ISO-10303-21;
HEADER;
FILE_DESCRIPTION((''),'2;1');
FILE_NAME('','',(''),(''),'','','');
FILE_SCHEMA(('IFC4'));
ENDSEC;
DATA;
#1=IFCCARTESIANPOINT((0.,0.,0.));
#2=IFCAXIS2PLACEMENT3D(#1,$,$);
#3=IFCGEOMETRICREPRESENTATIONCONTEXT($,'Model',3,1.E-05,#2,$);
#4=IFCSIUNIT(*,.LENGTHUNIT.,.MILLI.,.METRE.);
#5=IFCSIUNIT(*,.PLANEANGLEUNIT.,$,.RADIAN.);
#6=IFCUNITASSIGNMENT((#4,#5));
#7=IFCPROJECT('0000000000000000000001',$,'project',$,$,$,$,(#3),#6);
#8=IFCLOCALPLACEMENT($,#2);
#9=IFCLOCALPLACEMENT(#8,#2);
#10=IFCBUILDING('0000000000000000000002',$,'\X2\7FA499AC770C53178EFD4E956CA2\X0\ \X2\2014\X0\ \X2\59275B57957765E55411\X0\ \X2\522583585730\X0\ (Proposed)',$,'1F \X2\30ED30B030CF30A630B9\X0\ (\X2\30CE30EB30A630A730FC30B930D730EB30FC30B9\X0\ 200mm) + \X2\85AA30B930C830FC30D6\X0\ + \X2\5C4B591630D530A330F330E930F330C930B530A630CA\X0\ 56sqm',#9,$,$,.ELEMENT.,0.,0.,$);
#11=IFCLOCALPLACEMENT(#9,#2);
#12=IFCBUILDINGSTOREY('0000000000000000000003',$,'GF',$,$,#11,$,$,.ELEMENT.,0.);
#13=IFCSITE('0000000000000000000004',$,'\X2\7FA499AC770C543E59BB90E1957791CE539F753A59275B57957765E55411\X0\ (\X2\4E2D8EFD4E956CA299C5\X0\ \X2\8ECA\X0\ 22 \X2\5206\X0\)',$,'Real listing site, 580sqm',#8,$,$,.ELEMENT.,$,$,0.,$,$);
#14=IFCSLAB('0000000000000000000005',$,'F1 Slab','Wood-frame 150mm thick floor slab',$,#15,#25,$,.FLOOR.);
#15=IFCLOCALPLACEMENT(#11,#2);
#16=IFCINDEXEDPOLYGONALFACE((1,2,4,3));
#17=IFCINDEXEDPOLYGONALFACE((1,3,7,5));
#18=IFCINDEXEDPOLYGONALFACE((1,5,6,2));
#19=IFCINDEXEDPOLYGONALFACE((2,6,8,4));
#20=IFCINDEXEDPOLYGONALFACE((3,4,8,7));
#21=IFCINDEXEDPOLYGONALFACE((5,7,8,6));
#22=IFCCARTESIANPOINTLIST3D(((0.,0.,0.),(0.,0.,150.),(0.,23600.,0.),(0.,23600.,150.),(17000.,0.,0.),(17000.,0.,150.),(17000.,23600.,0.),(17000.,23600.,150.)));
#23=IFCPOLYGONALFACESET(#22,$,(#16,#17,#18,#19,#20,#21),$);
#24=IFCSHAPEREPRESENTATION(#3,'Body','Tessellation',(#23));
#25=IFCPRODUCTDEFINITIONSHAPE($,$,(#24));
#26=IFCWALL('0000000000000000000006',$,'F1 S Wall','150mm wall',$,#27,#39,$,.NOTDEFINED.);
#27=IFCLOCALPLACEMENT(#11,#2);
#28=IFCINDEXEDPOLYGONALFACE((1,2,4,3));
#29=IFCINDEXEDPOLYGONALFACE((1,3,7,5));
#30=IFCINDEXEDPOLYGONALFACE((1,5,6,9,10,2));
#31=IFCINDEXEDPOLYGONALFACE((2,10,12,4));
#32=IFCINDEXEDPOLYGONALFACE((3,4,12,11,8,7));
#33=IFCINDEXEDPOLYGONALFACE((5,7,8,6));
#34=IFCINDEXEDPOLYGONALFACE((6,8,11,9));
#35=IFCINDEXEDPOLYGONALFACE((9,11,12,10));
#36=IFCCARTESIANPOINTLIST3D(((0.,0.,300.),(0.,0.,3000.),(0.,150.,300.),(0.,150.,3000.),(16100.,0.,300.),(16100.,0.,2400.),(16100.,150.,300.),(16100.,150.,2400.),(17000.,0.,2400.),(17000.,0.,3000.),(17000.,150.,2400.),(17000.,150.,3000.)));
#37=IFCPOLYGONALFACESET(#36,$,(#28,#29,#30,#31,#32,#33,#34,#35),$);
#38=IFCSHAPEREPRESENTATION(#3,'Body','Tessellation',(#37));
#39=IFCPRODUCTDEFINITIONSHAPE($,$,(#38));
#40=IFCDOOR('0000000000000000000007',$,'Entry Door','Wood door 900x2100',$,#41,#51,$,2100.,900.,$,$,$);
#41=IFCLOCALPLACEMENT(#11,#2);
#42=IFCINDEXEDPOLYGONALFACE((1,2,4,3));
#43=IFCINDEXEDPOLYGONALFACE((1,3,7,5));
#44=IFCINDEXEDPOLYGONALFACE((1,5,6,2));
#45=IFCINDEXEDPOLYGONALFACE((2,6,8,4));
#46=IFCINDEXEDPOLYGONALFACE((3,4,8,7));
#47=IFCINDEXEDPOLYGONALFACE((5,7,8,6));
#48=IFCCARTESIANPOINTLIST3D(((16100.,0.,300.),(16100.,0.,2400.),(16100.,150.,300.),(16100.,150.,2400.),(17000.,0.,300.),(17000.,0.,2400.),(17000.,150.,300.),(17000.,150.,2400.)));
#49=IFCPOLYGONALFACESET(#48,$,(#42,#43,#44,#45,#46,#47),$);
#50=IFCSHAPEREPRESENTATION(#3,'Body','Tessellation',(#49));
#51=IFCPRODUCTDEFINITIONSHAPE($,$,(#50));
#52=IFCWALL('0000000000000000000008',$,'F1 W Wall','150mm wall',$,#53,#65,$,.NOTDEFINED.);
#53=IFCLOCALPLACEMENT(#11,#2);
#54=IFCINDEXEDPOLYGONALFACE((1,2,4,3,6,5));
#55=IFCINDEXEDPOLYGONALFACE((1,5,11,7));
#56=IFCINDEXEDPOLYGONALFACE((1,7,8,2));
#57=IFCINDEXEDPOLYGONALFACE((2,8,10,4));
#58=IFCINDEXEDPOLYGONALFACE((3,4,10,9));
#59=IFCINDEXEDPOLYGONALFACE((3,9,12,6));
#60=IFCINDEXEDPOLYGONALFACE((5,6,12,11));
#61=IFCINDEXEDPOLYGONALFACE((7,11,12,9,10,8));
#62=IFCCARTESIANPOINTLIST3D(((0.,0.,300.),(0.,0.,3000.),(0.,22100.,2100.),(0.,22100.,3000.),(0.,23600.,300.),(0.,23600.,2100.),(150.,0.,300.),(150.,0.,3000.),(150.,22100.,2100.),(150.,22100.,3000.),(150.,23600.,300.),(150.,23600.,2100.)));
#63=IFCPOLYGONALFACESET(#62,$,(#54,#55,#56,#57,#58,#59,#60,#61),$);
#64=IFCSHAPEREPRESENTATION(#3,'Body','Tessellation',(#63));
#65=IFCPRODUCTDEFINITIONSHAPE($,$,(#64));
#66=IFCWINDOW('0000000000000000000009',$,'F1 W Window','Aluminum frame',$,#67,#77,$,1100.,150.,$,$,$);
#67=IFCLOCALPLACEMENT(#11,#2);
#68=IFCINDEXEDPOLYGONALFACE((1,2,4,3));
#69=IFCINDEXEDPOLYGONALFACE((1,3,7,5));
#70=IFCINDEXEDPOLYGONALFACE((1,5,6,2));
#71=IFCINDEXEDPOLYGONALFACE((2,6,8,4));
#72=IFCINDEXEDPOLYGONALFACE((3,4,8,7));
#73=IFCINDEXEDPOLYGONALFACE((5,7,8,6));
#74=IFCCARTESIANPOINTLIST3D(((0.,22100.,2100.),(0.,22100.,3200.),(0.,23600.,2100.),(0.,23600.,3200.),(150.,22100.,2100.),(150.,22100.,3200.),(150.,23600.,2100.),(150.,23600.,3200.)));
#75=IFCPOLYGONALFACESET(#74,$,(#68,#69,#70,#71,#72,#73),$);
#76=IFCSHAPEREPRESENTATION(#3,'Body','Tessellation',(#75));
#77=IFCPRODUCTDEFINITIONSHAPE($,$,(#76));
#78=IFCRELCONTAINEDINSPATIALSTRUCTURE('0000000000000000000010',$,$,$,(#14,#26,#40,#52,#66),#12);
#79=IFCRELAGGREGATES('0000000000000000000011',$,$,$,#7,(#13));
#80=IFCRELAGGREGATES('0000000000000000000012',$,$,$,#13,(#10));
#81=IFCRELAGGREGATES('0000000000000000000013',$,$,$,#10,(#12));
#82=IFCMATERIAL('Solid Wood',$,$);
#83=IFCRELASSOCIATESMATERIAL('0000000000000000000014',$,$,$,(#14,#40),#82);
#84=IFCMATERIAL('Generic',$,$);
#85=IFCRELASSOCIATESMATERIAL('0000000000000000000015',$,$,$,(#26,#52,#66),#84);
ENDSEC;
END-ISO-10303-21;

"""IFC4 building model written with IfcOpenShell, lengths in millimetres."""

from ifc_helpers import new_model, si_unit, frame, frame_2d, origin, place, context, project, spatial, rectangle, extrude, material, element, fill, save


model = new_model("IFC4")

# Units and contexts
model_context = context("Model", 3, precision=1e-05, world=origin())
ifc_project = project(units=[si_unit("LENGTHUNIT", "METRE", prefix="MILLI"), si_unit("PLANEANGLEUNIT", "RADIAN")], contexts=[model_context])

# Site, building, storey
site_placement = place(None, origin())
site = spatial("IfcSite", under=ifc_project, at=site_placement, Name="群馬県吾妻郡長野原町大字長日向 (中軽井沢駅 車 22 分)", ObjectType="Real listing site, 580sqm", CompositionType="ELEMENT", RefElevation=0.0)
building_placement = place(site_placement, origin())
building = spatial("IfcBuilding", under=site, at=building_placement, Name="群馬県北軽井沢 — 大字長日向 別荘地 (Proposed)", ObjectType="1F ログハウス (ノルウェースプルース 200mm) + 薪ストーブ + 屋外フィンランドサウナ 56sqm", CompositionType="ELEMENT", ElevationOfRefHeight=0.0, ElevationOfTerrain=0.0)
storey_placement = place(building_placement, origin())
storey = spatial("IfcBuildingStorey", under=building, at=storey_placement, Name="GF", CompositionType="ELEMENT", Elevation=0.0)

# Slab
ifc_material_1 = material(Name="Solid Wood")
slab_placement = place(storey_placement, origin())
element("IfcSlab", 1, at=slab_placement, inside=storey, material=ifc_material_1, Name="F1 Slab", Description="Wood-frame 150mm thick floor slab", PredefinedType="FLOOR", context=model_context, shape_type="SweptSolid", body=[
    extrude(rectangle(XDim=17000.0, YDim=23600.0, at=frame_2d((8500.0, 11800.0))), origin(), (0.0, 0.0, 1.0), 150.0),
])

# Shared definitions
ifc_material_2 = material(Name="Generic")

# Wall, opening, door
wall_1_placement = place(storey_placement, frame((0.0, 0.0, 150.0)))
wall_1 = element("IfcWall", 2, at=wall_1_placement, inside=storey, material=ifc_material_2, Name="F1 S Wall", Description="150mm wall", PredefinedType="NOTDEFINED", context=model_context, shape_type="SweptSolid", body=[
    extrude(rectangle(XDim=17000.0, YDim=150.0, at=frame_2d((8500.0, 75.0))), frame((0.0, 0.0, 150.0)), (0.0, 0.0, 1.0), 2700.0),
])
opening_1_placement = place(storey_placement, frame((8050.0, 0.0, 150.0)))
opening_1 = element("IfcOpeningElement", 3, at=opening_1_placement, cuts=wall_1, PredefinedType="NOTDEFINED", context=model_context, shape_type="SweptSolid", body=[
    extrude(rectangle(XDim=900.0, YDim=150.0, at=frame_2d((450.0, 75.0))), frame((8050.0, 0.0, 150.0)), (0.0, 0.0, 1.0), 2100.0),
])
door_placement = place(storey_placement, frame((8050.0, 0.0, 150.0)))
door = element("IfcDoor", 4, at=door_placement, inside=storey, material=ifc_material_1, Name="Entry Door", Description="Wood door 900x2100", OverallHeight=2100.0, OverallWidth=900.0, context=model_context, shape_type="SweptSolid", body=[
    extrude(rectangle(XDim=900.0, YDim=150.0, at=frame_2d((450.0, 75.0))), frame((8050.0, 0.0, 150.0)), (0.0, 0.0, 1.0), 2100.0),
])
fill(opening_1, door)

# Wall, opening, window
wall_2_placement = place(storey_placement, frame((0.0, 0.0, 150.0)))
wall_2 = element("IfcWall", 5, at=wall_2_placement, inside=storey, material=ifc_material_2, Name="F1 W Wall", Description="150mm wall", PredefinedType="NOTDEFINED", context=model_context, shape_type="SweptSolid", body=[
    extrude(rectangle(XDim=150.0, YDim=23600.0, at=frame_2d((75.0, 11800.0))), frame((0.0, 0.0, 150.0)), (0.0, 0.0, 1.0), 2700.0),
])
opening_2_placement = place(storey_placement, frame((0.0, 11050.0, 1050.0)))
opening_2 = element("IfcOpeningElement", 6, at=opening_2_placement, cuts=wall_2, PredefinedType="NOTDEFINED", context=model_context, shape_type="SweptSolid", body=[
    extrude(rectangle(XDim=150.0, YDim=1500.0, at=frame_2d((75.0, 750.0))), frame((0.0, 11050.0, 1050.0)), (0.0, 0.0, 1.0), 1100.0),
])
window_1_placement = place(storey_placement, frame((0.0, 11050.0, 1050.0)))
window_1 = element("IfcWindow", 7, at=window_1_placement, inside=storey, material=ifc_material_2, Name="F1 W Window", Description="Aluminum frame", OverallHeight=1100.0, OverallWidth=150.0, context=model_context, shape_type="SweptSolid", body=[
    extrude(rectangle(XDim=150.0, YDim=1500.0, at=frame_2d((75.0, 750.0))), frame((0.0, 11050.0, 1050.0)), (0.0, 0.0, 1.0), 1100.0),
])
fill(opening_2, window_1)

save(model, "model.ifc")
